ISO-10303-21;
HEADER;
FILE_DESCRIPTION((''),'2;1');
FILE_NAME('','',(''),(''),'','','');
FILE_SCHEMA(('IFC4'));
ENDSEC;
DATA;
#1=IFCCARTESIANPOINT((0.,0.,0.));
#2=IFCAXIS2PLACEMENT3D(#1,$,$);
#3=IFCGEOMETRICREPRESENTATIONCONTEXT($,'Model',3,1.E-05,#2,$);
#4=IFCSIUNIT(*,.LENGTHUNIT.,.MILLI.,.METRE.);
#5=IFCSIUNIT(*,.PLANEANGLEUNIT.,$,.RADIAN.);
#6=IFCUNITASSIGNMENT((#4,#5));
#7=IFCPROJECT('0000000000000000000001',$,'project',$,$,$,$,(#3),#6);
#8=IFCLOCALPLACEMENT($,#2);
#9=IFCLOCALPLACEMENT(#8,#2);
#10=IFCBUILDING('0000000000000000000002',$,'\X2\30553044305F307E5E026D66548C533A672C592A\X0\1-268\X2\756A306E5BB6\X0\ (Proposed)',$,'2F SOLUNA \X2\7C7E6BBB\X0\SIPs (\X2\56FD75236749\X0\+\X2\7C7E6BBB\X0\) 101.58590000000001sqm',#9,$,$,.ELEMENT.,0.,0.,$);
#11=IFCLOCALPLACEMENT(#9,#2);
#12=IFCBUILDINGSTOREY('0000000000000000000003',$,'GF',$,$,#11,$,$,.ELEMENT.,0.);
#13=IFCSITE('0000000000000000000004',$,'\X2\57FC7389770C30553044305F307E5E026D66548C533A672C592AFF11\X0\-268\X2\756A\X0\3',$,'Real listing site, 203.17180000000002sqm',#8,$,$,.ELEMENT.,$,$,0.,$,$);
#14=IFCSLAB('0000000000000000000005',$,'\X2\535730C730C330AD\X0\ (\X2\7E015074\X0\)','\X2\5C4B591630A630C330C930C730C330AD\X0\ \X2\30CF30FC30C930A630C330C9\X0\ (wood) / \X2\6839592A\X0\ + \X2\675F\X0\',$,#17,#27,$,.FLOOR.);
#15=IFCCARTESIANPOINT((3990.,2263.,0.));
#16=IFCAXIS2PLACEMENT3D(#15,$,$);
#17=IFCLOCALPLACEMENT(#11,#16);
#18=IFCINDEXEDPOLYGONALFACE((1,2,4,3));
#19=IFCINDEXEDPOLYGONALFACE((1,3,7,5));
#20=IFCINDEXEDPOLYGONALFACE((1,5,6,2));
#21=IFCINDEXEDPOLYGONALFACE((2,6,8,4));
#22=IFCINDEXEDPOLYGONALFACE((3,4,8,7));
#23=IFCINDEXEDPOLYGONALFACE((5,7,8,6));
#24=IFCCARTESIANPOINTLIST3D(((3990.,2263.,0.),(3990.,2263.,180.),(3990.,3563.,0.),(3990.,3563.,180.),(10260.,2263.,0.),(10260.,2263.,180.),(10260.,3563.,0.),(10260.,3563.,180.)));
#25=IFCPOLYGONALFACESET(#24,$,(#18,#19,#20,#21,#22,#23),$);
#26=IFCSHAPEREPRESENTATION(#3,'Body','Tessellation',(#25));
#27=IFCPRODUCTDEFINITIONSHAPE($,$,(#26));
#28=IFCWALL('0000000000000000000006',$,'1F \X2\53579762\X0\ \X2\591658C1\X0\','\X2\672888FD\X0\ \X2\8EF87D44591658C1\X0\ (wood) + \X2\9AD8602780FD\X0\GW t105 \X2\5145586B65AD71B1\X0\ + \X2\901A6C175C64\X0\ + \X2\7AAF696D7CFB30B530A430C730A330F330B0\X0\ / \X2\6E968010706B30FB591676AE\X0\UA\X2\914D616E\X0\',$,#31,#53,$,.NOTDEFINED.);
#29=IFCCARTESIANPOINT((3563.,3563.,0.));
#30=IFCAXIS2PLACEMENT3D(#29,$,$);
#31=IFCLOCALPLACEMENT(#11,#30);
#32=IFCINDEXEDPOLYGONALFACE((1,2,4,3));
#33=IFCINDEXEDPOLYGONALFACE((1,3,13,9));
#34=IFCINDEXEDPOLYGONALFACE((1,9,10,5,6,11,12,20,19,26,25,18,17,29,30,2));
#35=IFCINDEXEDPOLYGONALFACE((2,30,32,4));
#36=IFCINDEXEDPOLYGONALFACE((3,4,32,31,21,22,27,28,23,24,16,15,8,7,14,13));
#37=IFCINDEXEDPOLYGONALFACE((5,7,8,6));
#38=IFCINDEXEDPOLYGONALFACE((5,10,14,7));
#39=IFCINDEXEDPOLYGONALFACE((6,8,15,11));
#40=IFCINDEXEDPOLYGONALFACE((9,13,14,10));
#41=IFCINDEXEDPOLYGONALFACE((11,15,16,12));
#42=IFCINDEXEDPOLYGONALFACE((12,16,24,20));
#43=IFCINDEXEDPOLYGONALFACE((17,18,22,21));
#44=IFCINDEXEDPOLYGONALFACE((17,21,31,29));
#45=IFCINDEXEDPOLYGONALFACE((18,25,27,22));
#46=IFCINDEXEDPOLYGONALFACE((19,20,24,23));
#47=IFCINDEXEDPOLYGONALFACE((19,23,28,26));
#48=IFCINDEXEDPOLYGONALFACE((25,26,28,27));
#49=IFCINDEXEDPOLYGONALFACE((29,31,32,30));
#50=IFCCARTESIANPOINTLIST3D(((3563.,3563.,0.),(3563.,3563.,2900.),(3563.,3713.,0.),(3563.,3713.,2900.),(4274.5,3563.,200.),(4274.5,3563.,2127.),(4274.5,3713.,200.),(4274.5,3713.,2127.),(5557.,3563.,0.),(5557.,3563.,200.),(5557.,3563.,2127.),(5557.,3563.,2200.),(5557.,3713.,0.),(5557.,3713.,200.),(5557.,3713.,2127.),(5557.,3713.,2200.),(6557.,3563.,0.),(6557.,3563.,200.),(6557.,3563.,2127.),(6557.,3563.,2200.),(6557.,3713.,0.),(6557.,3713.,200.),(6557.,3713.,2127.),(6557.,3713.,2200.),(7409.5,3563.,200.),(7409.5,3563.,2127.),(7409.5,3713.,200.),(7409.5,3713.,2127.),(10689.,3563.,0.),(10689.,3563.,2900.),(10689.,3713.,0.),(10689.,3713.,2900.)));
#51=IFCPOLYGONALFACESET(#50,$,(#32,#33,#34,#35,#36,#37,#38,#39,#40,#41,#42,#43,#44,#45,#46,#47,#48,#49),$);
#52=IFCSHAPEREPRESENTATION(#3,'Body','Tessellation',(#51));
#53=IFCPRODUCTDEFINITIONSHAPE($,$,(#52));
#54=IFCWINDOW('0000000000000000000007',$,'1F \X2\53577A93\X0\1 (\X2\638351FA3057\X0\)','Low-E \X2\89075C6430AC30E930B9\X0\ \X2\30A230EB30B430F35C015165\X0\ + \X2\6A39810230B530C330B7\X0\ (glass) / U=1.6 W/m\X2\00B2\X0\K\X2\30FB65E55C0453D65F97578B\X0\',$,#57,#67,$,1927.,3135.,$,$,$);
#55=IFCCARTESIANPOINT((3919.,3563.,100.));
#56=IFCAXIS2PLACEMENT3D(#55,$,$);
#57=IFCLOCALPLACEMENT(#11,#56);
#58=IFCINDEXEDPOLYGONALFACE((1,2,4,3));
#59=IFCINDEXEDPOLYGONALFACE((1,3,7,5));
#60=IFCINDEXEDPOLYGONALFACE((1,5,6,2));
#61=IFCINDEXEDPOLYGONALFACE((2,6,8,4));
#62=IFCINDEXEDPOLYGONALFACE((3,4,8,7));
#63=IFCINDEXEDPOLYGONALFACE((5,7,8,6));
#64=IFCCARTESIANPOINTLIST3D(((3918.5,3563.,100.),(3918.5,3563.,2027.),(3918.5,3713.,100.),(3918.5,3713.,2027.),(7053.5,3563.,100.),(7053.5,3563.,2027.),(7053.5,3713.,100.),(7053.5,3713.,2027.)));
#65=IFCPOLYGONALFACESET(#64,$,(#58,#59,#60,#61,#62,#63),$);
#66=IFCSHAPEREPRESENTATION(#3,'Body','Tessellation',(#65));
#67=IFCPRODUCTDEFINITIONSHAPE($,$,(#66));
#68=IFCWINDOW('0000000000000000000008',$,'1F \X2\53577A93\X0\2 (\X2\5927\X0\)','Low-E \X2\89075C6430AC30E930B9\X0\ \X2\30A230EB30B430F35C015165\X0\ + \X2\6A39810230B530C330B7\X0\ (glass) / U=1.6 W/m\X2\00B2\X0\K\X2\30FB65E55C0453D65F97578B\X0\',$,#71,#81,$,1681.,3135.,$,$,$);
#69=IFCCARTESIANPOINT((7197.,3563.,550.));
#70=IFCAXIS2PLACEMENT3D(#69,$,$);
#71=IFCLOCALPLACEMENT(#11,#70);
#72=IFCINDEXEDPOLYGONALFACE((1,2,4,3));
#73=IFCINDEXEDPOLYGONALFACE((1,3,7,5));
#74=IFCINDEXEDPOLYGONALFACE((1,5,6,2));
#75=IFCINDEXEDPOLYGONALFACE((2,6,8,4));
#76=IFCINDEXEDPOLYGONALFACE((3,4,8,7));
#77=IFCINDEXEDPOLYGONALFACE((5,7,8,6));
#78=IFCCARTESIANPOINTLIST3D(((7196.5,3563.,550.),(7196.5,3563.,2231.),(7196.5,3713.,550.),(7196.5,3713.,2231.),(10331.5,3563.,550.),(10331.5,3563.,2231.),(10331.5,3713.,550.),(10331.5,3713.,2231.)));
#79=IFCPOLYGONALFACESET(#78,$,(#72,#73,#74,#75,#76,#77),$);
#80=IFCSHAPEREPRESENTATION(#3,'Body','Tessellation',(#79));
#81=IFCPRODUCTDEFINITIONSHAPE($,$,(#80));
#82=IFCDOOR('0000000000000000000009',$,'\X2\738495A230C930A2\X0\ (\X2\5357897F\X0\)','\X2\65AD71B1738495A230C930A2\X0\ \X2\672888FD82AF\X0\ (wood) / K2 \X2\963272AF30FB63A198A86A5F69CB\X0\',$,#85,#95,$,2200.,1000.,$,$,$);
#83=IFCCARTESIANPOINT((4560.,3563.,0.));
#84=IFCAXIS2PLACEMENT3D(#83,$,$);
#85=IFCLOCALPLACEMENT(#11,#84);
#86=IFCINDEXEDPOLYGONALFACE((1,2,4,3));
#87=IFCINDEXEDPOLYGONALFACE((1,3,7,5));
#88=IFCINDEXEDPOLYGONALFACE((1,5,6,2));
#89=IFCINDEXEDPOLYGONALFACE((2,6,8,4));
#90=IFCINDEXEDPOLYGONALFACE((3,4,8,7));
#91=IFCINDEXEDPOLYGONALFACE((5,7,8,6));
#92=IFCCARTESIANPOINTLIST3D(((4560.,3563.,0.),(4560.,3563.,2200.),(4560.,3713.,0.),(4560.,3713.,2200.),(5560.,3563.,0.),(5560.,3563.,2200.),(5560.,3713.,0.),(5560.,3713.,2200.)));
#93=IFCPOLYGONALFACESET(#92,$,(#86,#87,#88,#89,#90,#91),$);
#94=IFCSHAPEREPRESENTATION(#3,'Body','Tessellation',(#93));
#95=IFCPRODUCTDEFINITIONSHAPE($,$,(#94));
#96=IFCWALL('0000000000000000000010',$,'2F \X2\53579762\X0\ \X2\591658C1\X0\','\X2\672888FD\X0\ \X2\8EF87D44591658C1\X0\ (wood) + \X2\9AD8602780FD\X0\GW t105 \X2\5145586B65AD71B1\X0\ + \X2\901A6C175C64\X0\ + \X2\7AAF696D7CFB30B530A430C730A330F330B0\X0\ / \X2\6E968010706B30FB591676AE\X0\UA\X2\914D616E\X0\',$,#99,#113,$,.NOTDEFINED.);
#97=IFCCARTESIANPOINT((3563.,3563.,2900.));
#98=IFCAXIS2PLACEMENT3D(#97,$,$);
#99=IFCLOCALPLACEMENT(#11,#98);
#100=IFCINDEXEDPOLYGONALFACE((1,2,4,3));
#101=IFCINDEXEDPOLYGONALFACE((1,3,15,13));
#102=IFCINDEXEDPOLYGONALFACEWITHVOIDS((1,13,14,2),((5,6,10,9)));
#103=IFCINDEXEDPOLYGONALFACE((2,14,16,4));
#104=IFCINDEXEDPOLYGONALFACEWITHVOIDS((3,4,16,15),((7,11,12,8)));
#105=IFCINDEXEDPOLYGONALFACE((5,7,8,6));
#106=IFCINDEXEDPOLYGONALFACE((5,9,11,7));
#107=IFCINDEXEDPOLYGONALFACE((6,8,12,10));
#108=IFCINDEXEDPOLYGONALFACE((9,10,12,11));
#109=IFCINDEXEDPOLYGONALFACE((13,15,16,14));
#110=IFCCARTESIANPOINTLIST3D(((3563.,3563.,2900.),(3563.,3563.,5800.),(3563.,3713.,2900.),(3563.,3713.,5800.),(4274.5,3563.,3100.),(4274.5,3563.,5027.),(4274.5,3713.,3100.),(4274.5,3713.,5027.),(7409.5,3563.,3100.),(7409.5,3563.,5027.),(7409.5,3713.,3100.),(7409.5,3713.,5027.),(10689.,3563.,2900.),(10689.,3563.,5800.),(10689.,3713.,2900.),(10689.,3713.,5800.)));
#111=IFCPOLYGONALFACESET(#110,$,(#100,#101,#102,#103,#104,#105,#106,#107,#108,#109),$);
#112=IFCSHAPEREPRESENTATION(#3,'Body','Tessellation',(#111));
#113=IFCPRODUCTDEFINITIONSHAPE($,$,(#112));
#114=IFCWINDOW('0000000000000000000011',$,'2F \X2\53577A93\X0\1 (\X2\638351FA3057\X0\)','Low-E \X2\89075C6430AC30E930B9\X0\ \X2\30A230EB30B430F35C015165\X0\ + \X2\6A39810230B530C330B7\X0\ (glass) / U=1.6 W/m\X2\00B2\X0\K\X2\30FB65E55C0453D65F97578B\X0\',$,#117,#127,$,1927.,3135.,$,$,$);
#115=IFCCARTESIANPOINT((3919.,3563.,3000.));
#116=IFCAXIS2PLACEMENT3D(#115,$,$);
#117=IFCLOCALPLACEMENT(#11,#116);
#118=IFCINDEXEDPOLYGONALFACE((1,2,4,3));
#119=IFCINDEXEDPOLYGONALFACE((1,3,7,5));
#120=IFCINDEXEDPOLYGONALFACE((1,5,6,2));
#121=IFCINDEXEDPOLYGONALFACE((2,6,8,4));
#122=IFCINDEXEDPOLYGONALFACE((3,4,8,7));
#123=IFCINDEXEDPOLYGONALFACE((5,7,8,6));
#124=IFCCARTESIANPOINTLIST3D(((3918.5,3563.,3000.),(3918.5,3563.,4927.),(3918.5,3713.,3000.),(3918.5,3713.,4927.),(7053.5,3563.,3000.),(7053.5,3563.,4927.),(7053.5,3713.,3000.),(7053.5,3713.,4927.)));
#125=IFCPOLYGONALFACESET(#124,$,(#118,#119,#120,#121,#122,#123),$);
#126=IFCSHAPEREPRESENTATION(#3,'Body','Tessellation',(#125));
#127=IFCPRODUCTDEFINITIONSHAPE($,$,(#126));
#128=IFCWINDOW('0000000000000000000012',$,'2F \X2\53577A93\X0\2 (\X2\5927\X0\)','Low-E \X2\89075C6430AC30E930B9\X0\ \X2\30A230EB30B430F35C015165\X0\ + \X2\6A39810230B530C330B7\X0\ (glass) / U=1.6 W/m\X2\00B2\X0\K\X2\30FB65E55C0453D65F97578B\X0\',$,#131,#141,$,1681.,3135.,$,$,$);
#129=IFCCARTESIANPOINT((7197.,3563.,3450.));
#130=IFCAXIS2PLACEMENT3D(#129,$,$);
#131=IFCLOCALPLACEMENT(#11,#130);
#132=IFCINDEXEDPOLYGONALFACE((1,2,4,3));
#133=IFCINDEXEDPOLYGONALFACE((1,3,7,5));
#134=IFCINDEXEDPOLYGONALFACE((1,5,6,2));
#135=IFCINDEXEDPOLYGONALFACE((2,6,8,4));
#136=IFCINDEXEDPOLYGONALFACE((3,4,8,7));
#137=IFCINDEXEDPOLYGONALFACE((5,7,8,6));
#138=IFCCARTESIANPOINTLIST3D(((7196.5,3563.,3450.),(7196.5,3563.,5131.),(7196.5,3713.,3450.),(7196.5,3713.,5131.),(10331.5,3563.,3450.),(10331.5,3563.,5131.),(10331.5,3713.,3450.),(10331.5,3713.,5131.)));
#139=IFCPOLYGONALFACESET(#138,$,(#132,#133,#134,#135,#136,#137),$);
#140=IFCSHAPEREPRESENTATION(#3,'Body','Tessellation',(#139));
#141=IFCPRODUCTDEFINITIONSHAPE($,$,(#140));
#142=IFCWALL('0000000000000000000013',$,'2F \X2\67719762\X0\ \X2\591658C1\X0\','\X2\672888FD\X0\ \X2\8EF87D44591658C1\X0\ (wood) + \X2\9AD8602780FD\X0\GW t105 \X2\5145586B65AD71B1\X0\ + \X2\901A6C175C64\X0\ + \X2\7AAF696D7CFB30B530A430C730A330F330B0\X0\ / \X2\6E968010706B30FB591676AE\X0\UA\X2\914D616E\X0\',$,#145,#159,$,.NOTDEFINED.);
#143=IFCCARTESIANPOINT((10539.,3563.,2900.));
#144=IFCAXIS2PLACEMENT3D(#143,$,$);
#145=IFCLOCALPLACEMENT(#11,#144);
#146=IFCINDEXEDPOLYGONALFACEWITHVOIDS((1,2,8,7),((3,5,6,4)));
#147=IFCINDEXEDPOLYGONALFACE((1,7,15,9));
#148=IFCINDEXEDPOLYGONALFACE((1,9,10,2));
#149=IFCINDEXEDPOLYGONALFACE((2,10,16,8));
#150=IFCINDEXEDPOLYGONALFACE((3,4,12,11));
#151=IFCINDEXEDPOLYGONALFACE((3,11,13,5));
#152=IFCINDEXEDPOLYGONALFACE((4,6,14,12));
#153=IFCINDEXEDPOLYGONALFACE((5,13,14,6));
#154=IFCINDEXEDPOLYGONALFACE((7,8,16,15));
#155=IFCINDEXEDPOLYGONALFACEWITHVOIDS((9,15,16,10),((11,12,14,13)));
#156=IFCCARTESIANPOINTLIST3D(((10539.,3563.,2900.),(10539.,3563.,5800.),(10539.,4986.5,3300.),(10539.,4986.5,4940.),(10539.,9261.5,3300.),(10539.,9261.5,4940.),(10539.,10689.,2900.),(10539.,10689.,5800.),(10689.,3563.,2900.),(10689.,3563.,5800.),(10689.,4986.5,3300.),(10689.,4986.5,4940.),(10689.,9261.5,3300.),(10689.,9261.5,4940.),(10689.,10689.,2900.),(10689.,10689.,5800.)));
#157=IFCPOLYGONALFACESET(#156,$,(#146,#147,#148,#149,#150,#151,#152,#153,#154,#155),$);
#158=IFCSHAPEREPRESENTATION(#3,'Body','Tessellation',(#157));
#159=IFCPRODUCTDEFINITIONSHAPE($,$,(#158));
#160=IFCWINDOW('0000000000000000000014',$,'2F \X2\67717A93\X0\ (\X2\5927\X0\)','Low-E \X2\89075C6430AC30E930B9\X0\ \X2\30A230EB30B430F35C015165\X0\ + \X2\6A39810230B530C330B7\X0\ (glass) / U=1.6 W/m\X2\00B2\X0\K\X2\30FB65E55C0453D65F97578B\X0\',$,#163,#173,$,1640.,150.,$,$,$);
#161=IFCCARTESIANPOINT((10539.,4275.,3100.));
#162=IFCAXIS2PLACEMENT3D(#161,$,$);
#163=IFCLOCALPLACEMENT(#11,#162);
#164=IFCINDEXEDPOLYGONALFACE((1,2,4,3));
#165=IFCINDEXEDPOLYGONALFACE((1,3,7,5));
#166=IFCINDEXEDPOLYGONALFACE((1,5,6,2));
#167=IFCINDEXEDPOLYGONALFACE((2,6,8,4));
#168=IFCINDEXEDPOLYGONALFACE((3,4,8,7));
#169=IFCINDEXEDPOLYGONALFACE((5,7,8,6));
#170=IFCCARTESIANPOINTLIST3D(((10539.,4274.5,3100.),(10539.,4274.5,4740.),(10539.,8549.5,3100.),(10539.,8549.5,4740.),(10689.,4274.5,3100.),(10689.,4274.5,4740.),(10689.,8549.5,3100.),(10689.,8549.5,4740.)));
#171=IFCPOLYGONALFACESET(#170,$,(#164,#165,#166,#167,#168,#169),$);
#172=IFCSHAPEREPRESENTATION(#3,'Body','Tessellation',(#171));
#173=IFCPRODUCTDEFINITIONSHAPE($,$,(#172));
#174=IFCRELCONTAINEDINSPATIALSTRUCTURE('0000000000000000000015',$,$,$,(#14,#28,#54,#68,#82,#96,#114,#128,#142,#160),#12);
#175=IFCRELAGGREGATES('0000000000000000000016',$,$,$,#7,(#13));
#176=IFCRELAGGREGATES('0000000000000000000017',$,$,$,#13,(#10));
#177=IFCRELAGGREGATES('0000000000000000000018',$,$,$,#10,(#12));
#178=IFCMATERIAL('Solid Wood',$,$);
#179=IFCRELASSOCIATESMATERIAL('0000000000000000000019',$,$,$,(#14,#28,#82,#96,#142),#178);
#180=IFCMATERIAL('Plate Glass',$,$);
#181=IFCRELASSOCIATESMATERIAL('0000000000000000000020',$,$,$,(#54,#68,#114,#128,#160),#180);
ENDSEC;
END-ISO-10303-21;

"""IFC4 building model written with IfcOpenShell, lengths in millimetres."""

from ifc_helpers import new_model, si_unit, frame, frame_2d, origin, place, context, project, spatial, rectangle, extrude, material, element, fill, save


model = new_model("IFC4")

# Units and contexts
model_context = context("Model", 3, precision=1e-05, world=origin())
ifc_project = project(units=[si_unit("LENGTHUNIT", "METRE", prefix="MILLI"), si_unit("PLANEANGLEUNIT", "RADIAN")], contexts=[model_context])

# Site, building, storey
site_placement = place(None, origin())
site = spatial("IfcSite", under=ifc_project, at=site_placement, Name="埼玉県さいたま市浦和区本太１-268番3", ObjectType="Real listing site, 203.17180000000002sqm", CompositionType="ELEMENT", RefElevation=0.0)
building_placement = place(site_placement, origin())
building = spatial("IfcBuilding", under=site, at=building_placement, Name="さいたま市浦和区本太1-268番の家 (Proposed)", ObjectType="2F SOLUNA 籾殻SIPs (国産杉+籾殻) 101.58590000000001sqm", CompositionType="ELEMENT", ElevationOfRefHeight=0.0, ElevationOfTerrain=0.0)
storey_placement = place(building_placement, origin())
storey = spatial("IfcBuildingStorey", under=building, at=storey_placement, Name="GF", CompositionType="ELEMENT", Elevation=0.0)

# Slab
ifc_material_1 = material(Name="Solid Wood")
slab_1_placement = place(storey_placement, frame((3990.0, 2263.0, 0.0)))
element("IfcSlab", 1, at=slab_1_placement, inside=storey, material=ifc_material_1, Name="南デッキ (縁側)", Description="屋外ウッドデッキ ハードウッド (wood) / 根太 + 束", PredefinedType="FLOOR", context=model_context, shape_type="SweptSolid", body=[
    extrude(rectangle(XDim=6270.0, YDim=1300.0, at=frame_2d((3135.0, 650.0))), frame((3990.0, 2263.0, 0.0)), (0.0, 0.0, 1.0), 180.0),
])

# Wall, openings, windows, door
wall_1_placement = place(storey_placement, frame((3563.0, 3563.0, 0.0)))
wall_1 = element("IfcWall", 2, at=wall_1_placement, inside=storey, material=ifc_material_1, Name="1F 南面 外壁", Description="木製 軸組外壁 (wood) + 高性能GW t105 充填断熱 + 通気層 + 窯業系サイディング / 準耐火・外皮UA配慮", PredefinedType="NOTDEFINED", context=model_context, shape_type="SweptSolid", body=[
    extrude(rectangle(XDim=7126.0, YDim=150.0, at=frame_2d((3563.0, 75.0))), frame((3563.0, 3563.0, 0.0)), (0.0, 0.0, 1.0), 2900.0),
])
opening_1_placement = place(storey_placement, frame((3919.0, 3563.0, 100.0)))
opening_1 = element("IfcOpeningElement", 3, at=opening_1_placement, cuts=wall_1, PredefinedType="NOTDEFINED", context=model_context, shape_type="SweptSolid", body=[
    extrude(rectangle(XDim=3135.0, YDim=150.0, at=frame_2d((1567.0, 75.0))), frame((3919.0, 3563.0, 100.0)), (0.0, 0.0, 1.0), 1927.0),
])
opening_2_placement = place(storey_placement, frame((7197.0, 3563.0, 550.0)))
opening_2 = element("IfcOpeningElement", 4, at=opening_2_placement, cuts=wall_1, PredefinedType="NOTDEFINED", context=model_context, shape_type="SweptSolid", body=[
    extrude(rectangle(XDim=3135.0, YDim=150.0, at=frame_2d((1567.0, 75.0))), frame((7197.0, 3563.0, 550.0)), (0.0, 0.0, 1.0), 1681.0),
])
opening_3_placement = place(storey_placement, frame((4560.0, 3563.0, 0.0)))
opening_3 = element("IfcOpeningElement", 5, at=opening_3_placement, cuts=wall_1, PredefinedType="NOTDEFINED", context=model_context, shape_type="SweptSolid", body=[
    extrude(rectangle(XDim=1000.0, YDim=150.0, at=frame_2d((500.0, 75.0))), frame((4560.0, 3563.0, 0.0)), (0.0, 0.0, 1.0), 2200.0),
])
ifc_material_2 = material(Name="Plate Glass")
window_1_placement = place(storey_placement, frame((3919.0, 3563.0, 100.0)))
window_1 = element("IfcWindow", 6, at=window_1_placement, inside=storey, material=ifc_material_2, Name="1F 南窓1 (掃出し)", Description="Low-E 複層ガラス アルゴン封入 + 樹脂サッシ (glass) / U=1.6 W/m²K・日射取得型", OverallHeight=1927.0, OverallWidth=3135.0, context=model_context, shape_type="SweptSolid", body=[
    extrude(rectangle(XDim=3135.0, YDim=150.0, at=frame_2d((1567.0, 75.0))), frame((3919.0, 3563.0, 100.0)), (0.0, 0.0, 1.0), 1927.0),
])
fill(opening_1, window_1)
window_2_placement = place(storey_placement, frame((7197.0, 3563.0, 550.0)))
window_2 = element("IfcWindow", 7, at=window_2_placement, inside=storey, material=ifc_material_2, Name="1F 南窓2 (大)", Description="Low-E 複層ガラス アルゴン封入 + 樹脂サッシ (glass) / U=1.6 W/m²K・日射取得型", OverallHeight=1681.0, OverallWidth=3135.0, context=model_context, shape_type="SweptSolid", body=[
    extrude(rectangle(XDim=3135.0, YDim=150.0, at=frame_2d((1567.0, 75.0))), frame((7197.0, 3563.0, 550.0)), (0.0, 0.0, 1.0), 1681.0),
])
fill(opening_2, window_2)
door_placement = place(storey_placement, frame((4560.0, 3563.0, 0.0)))
door = element("IfcDoor", 8, at=door_placement, inside=storey, material=ifc_material_1, Name="玄関ドア (南西)", Description="断熱玄関ドア 木製芯 (wood) / K2 防犯・採風機構", OverallHeight=2200.0, OverallWidth=1000.0, context=model_context, shape_type="SweptSolid", body=[
    extrude(rectangle(XDim=1000.0, YDim=150.0, at=frame_2d((500.0, 75.0))), frame((4560.0, 3563.0, 0.0)), (0.0, 0.0, 1.0), 2200.0),
])
fill(opening_3, door)

# Wall, openings, windows
wall_2_placement = place(storey_placement, frame((3563.0, 3563.0, 2900.0)))
wall_2 = element("IfcWall", 9, at=wall_2_placement, inside=storey, material=ifc_material_1, Name="2F 南面 外壁", Description="木製 軸組外壁 (wood) + 高性能GW t105 充填断熱 + 通気層 + 窯業系サイディング / 準耐火・外皮UA配慮", PredefinedType="NOTDEFINED", context=model_context, shape_type="SweptSolid", body=[
    extrude(rectangle(XDim=7126.0, YDim=150.0, at=frame_2d((3563.0, 75.0))), frame((3563.0, 3563.0, 2900.0)), (0.0, 0.0, 1.0), 2900.0),
])
opening_4_placement = place(storey_placement, frame((3919.0, 3563.0, 3000.0)))
opening_4 = element("IfcOpeningElement", 10, at=opening_4_placement, cuts=wall_2, PredefinedType="NOTDEFINED", context=model_context, shape_type="SweptSolid", body=[
    extrude(rectangle(XDim=3135.0, YDim=150.0, at=frame_2d((1567.0, 75.0))), frame((3919.0, 3563.0, 3000.0)), (0.0, 0.0, 1.0), 1927.0),
])
opening_5_placement = place(storey_placement, frame((7197.0, 3563.0, 3450.0)))
opening_5 = element("IfcOpeningElement", 11, at=opening_5_placement, cuts=wall_2, PredefinedType="NOTDEFINED", context=model_context, shape_type="SweptSolid", body=[
    extrude(rectangle(XDim=3135.0, YDim=150.0, at=frame_2d((1567.0, 75.0))), frame((7197.0, 3563.0, 3450.0)), (0.0, 0.0, 1.0), 1681.0),
])
window_3_placement = place(storey_placement, frame((3919.0, 3563.0, 3000.0)))
window_3 = element("IfcWindow", 12, at=window_3_placement, inside=storey, material=ifc_material_2, Name="2F 南窓1 (掃出し)", Description="Low-E 複層ガラス アルゴン封入 + 樹脂サッシ (glass) / U=1.6 W/m²K・日射取得型", OverallHeight=1927.0, OverallWidth=3135.0, context=model_context, shape_type="SweptSolid", body=[
    extrude(rectangle(XDim=3135.0, YDim=150.0, at=frame_2d((1567.0, 75.0))), frame((3919.0, 3563.0, 3000.0)), (0.0, 0.0, 1.0), 1927.0),
])
fill(opening_4, window_3)
window_4_placement = place(storey_placement, frame((7197.0, 3563.0, 3450.0)))
window_4 = element("IfcWindow", 13, at=window_4_placement, inside=storey, material=ifc_material_2, Name="2F 南窓2 (大)", Description="Low-E 複層ガラス アルゴン封入 + 樹脂サッシ (glass) / U=1.6 W/m²K・日射取得型", OverallHeight=1681.0, OverallWidth=3135.0, context=model_context, shape_type="SweptSolid", body=[
    extrude(rectangle(XDim=3135.0, YDim=150.0, at=frame_2d((1567.0, 75.0))), frame((7197.0, 3563.0, 3450.0)), (0.0, 0.0, 1.0), 1681.0),
])
fill(opening_5, window_4)

# Wall, opening, window
wall_3_placement = place(storey_placement, frame((10539.0, 3563.0, 2900.0)))
wall_3 = element("IfcWall", 14, at=wall_3_placement, inside=storey, material=ifc_material_1, Name="2F 東面 外壁", Description="木製 軸組外壁 (wood) + 高性能GW t105 充填断熱 + 通気層 + 窯業系サイディング / 準耐火・外皮UA配慮", PredefinedType="NOTDEFINED", context=model_context, shape_type="SweptSolid", body=[
    extrude(rectangle(XDim=150.0, YDim=7126.0, at=frame_2d((75.0, 3563.0))), frame((10539.0, 3563.0, 2900.0)), (0.0, 0.0, 1.0), 2900.0),
])
opening_6_placement = place(storey_placement, frame((10539.0, 4275.0, 3100.0)))
opening_6 = element("IfcOpeningElement", 15, at=opening_6_placement, cuts=wall_3, PredefinedType="NOTDEFINED", context=model_context, shape_type="SweptSolid", body=[
    extrude(rectangle(XDim=150.0, YDim=4275.0, at=frame_2d((75.0, 2137.0))), frame((10539.0, 4275.0, 3100.0)), (0.0, 0.0, 1.0), 1640.0),
])
window_5_placement = place(storey_placement, frame((10539.0, 4275.0, 3100.0)))
window_5 = element("IfcWindow", 16, at=window_5_placement, inside=storey, material=ifc_material_2, Name="2F 東窓 (大)", Description="Low-E 複層ガラス アルゴン封入 + 樹脂サッシ (glass) / U=1.6 W/m²K・日射取得型", OverallHeight=1640.0, OverallWidth=150.0, context=model_context, shape_type="SweptSolid", body=[
    extrude(rectangle(XDim=150.0, YDim=4275.0, at=frame_2d((75.0, 2137.0))), frame((10539.0, 4275.0, 3100.0)), (0.0, 0.0, 1.0), 1640.0),
])
fill(opening_6, window_5)

save(model, "model.ifc")
